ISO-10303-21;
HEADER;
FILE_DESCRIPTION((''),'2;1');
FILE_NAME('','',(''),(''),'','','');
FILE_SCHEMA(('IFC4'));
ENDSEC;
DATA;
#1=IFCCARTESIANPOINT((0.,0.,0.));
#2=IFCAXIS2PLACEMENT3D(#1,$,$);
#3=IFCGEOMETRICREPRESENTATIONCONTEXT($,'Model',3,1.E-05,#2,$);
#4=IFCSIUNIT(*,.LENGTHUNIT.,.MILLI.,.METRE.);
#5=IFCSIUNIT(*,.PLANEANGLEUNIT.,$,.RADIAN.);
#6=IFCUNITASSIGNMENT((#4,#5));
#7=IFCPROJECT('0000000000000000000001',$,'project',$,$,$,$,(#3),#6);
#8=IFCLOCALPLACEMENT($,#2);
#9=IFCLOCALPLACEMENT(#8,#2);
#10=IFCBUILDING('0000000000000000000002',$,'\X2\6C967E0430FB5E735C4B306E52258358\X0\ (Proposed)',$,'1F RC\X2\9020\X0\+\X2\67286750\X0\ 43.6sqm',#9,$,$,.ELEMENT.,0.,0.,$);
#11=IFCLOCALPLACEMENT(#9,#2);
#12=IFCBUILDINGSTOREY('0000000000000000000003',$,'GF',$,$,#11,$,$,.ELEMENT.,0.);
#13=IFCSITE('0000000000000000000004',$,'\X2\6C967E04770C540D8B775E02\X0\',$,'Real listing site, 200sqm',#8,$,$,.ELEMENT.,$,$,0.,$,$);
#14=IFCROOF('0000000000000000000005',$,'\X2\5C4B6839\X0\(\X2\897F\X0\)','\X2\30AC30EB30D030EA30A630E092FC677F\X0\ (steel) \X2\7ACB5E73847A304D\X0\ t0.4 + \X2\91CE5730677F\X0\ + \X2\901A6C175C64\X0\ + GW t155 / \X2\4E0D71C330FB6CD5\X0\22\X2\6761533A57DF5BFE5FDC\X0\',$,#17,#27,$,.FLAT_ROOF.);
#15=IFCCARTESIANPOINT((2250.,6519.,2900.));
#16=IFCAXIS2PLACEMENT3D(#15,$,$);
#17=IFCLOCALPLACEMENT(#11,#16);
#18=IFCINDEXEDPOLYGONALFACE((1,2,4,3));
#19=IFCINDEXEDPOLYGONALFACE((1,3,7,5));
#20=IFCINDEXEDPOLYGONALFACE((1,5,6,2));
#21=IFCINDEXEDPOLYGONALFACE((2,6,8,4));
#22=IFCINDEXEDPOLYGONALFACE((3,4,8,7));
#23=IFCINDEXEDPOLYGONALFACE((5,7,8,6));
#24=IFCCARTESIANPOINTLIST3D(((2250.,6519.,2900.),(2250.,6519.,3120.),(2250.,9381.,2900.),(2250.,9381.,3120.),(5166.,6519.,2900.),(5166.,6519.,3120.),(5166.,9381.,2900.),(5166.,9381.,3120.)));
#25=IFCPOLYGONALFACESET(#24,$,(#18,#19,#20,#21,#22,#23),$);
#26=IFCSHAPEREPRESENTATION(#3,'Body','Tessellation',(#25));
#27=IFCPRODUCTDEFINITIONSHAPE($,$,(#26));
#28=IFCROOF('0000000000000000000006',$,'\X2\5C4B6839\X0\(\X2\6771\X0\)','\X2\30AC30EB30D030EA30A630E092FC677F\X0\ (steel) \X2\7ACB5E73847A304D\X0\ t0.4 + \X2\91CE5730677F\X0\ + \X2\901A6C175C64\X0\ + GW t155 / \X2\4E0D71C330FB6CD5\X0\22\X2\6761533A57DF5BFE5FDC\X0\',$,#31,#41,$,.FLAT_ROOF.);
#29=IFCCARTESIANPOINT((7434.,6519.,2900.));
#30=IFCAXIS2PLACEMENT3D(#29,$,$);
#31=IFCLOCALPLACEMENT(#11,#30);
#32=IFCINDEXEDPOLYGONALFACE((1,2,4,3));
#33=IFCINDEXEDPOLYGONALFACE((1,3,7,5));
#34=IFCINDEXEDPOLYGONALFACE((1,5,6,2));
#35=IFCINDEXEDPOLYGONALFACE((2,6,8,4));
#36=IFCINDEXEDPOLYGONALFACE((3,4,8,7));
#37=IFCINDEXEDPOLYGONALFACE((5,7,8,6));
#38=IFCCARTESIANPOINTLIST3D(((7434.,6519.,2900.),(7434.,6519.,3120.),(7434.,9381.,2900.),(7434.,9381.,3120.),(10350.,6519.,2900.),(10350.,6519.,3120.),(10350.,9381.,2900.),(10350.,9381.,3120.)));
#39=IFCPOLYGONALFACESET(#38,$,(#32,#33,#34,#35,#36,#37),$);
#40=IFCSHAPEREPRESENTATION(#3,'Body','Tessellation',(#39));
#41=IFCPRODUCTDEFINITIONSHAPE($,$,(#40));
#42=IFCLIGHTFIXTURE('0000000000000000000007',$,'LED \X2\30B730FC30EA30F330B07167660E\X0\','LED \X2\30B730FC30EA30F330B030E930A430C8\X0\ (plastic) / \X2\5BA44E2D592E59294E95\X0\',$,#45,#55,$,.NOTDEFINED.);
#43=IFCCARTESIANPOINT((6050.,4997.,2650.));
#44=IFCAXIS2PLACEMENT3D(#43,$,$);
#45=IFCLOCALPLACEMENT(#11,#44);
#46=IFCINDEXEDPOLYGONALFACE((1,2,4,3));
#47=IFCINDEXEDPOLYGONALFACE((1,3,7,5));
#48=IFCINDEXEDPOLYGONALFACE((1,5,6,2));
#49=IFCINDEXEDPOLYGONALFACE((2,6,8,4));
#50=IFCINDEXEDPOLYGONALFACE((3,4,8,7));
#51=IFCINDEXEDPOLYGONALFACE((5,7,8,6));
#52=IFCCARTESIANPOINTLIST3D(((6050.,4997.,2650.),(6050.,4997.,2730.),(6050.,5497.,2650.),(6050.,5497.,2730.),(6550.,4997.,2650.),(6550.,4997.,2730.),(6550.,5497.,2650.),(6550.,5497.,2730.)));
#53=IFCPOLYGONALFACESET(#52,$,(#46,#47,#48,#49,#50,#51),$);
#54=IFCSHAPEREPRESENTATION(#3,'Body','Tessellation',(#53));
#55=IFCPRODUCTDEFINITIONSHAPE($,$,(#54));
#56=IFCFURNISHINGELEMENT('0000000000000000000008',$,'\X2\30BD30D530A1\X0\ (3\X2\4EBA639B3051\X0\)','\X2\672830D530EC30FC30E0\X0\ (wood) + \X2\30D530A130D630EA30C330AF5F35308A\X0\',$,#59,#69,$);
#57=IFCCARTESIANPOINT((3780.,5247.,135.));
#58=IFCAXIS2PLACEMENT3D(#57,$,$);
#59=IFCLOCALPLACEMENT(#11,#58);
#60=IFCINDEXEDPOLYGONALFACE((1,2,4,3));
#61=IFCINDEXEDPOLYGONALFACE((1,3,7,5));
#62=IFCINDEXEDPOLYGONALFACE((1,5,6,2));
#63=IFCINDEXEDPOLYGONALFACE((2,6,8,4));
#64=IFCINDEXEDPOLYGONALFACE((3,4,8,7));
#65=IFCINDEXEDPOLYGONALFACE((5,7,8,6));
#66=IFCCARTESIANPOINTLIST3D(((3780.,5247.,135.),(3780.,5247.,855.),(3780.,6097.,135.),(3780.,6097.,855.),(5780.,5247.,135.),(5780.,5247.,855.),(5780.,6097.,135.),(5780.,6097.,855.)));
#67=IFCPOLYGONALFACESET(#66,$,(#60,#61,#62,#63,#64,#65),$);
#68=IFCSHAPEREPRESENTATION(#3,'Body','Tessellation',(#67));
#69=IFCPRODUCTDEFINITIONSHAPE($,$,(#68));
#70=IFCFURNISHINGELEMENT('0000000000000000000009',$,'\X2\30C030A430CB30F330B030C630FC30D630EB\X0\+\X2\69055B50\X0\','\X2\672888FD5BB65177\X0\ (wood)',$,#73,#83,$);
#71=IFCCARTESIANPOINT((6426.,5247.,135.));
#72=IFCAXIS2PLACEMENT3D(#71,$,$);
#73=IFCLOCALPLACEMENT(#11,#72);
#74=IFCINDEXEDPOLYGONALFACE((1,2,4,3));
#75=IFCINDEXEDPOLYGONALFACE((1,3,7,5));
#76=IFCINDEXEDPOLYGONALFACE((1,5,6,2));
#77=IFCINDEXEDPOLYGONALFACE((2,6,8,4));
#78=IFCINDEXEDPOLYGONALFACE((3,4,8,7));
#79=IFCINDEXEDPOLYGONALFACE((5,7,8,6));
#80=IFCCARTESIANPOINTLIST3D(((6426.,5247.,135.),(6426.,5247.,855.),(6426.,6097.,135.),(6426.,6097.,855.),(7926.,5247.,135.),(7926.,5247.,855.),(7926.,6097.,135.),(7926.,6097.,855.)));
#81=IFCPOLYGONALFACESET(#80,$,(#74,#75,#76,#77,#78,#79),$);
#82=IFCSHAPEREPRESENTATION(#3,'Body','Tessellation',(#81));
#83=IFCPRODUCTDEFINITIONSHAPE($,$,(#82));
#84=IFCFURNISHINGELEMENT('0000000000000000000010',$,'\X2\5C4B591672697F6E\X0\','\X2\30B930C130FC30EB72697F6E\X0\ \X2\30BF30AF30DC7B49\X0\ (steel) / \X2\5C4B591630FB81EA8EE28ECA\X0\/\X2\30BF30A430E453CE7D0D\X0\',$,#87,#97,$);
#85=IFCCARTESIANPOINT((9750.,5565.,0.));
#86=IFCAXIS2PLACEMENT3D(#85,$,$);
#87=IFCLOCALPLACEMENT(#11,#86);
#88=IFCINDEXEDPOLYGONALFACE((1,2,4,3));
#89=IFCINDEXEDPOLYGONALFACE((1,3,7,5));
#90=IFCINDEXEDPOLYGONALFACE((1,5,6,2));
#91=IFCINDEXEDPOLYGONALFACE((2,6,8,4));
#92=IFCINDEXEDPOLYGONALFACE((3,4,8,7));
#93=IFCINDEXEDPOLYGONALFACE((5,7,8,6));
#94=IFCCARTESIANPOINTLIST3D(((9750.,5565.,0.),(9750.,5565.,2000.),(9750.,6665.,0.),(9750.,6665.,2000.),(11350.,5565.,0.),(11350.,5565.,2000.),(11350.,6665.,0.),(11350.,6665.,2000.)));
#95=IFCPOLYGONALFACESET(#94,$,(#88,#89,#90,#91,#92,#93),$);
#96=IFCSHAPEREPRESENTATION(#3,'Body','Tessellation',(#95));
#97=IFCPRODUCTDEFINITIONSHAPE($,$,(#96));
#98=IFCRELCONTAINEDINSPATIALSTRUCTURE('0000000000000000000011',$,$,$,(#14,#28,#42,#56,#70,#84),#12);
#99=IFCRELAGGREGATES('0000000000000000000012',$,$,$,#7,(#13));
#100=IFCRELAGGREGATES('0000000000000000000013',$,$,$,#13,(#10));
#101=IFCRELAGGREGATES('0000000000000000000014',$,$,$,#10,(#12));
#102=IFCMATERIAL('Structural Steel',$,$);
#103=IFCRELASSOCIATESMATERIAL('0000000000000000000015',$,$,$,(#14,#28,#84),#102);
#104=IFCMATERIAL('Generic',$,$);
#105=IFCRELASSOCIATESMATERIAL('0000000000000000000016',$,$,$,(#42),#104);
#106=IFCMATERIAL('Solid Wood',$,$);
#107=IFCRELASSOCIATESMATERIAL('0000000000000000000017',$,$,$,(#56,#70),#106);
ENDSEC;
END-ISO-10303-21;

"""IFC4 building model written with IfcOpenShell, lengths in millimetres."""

from ifc_helpers import new_model, si_unit, frame, frame_2d, origin, place, context, project, spatial, rectangle, extrude, material, element, save


model = new_model("IFC4")

# Units and contexts
model_context = context("Model", 3, precision=1e-05, world=origin())
ifc_project = project(units=[si_unit("LENGTHUNIT", "METRE", prefix="MILLI"), si_unit("PLANEANGLEUNIT", "RADIAN")], contexts=[model_context])

# Site, building, storey
site_placement = place(None, origin())
site = spatial("IfcSite", under=ifc_project, at=site_placement, Name="沖縄県名護市", ObjectType="Real listing site, 200sqm", CompositionType="ELEMENT", RefElevation=0.0)
building_placement = place(site_placement, origin())
building = spatial("IfcBuilding", under=site, at=building_placement, Name="沖縄・平屋の別荘 (Proposed)", ObjectType="1F RC造+木材 43.6sqm", CompositionType="ELEMENT", ElevationOfRefHeight=0.0, ElevationOfTerrain=0.0)
storey_placement = place(building_placement, origin())
storey = spatial("IfcBuildingStorey", under=building, at=storey_placement, Name="GF", CompositionType="ELEMENT", Elevation=0.0)

# Shared definitions
ifc_material_1 = material(Name="Solid Wood")

# Roofs
ifc_material_2 = material(Name="Structural Steel")
roof_1_placement = place(storey_placement, frame((2250.0, 6519.0, 2900.0)))
element("IfcRoof", 1, at=roof_1_placement, inside=storey, material=ifc_material_2, Name="屋根(西)", Description="ガルバリウム鋼板 (steel) 立平葺き t0.4 + 野地板 + 通気層 + GW t155 / 不燃・法22条区域対応", PredefinedType="FLAT_ROOF", context=model_context, shape_type="SweptSolid", body=[
    extrude(rectangle(XDim=2916.0, YDim=2862.0, at=frame_2d((1458.0, 1431.0))), frame((2250.0, 6519.0, 2900.0)), (0.0, 0.0, 1.0), 220.0),
])
roof_2_placement = place(storey_placement, frame((7434.0, 6519.0, 2900.0)))
element("IfcRoof", 2, at=roof_2_placement, inside=storey, material=ifc_material_2, Name="屋根(東)", Description="ガルバリウム鋼板 (steel) 立平葺き t0.4 + 野地板 + 通気層 + GW t155 / 不燃・法22条区域対応", PredefinedType="FLAT_ROOF", context=model_context, shape_type="SweptSolid", body=[
    extrude(rectangle(XDim=2916.0, YDim=2862.0, at=frame_2d((1458.0, 1431.0))), frame((7434.0, 6519.0, 2900.0)), (0.0, 0.0, 1.0), 220.0),
])

# Light fixture
ifc_material_3 = material(Name="Generic")
light_fixture_placement = place(storey_placement, frame((6050.0, 4997.0, 2650.0)))
element("IfcLightFixture", 3, at=light_fixture_placement, inside=storey, material=ifc_material_3, Name="LED シーリング照明", Description="LED シーリングライト (plastic) / 室中央天井", PredefinedType="NOTDEFINED", context=model_context, shape_type="SweptSolid", body=[
    extrude(rectangle(XDim=500.0, YDim=500.0, at=frame_2d((250.0, 250.0))), frame((6050.0, 4997.0, 2650.0)), (0.0, 0.0, 1.0), 80.0),
])

# Furnishing elements
furnishing_1_placement = place(storey_placement, frame((3780.0, 5247.0, 135.0)))
element("IfcFurnishingElement", 4, at=furnishing_1_placement, inside=storey, material=ifc_material_1, Name="ソファ (3人掛け)", Description="木フレーム (wood) + ファブリック張り", context=model_context, shape_type="SweptSolid", body=[
    extrude(rectangle(XDim=2000.0, YDim=850.0, at=frame_2d((1000.0, 425.0))), frame((3780.0, 5247.0, 135.0)), (0.0, 0.0, 1.0), 720.0),
])
furnishing_2_placement = place(storey_placement, frame((6426.0, 5247.0, 135.0)))
element("IfcFurnishingElement", 5, at=furnishing_2_placement, inside=storey, material=ifc_material_1, Name="ダイニングテーブル+椅子", Description="木製家具 (wood)", context=model_context, shape_type="SweptSolid", body=[
    extrude(rectangle(XDim=1500.0, YDim=850.0, at=frame_2d((750.0, 425.0))), frame((6426.0, 5247.0, 135.0)), (0.0, 0.0, 1.0), 720.0),
])
furnishing_3_placement = place(storey_placement, frame((9750.0, 5565.0, 0.0)))
element("IfcFurnishingElement", 6, at=furnishing_3_placement, inside=storey, material=ifc_material_2, Name="屋外物置", Description="スチール物置 タクボ等 (steel) / 屋外・自転車/タイヤ収納", context=model_context, shape_type="SweptSolid", body=[
    extrude(rectangle(XDim=1600.0, YDim=1100.0, at=frame_2d((800.0, 550.0))), frame((9750.0, 5565.0, 0.0)), (0.0, 0.0, 1.0), 2000.0),
])

save(model, "model.ifc")
